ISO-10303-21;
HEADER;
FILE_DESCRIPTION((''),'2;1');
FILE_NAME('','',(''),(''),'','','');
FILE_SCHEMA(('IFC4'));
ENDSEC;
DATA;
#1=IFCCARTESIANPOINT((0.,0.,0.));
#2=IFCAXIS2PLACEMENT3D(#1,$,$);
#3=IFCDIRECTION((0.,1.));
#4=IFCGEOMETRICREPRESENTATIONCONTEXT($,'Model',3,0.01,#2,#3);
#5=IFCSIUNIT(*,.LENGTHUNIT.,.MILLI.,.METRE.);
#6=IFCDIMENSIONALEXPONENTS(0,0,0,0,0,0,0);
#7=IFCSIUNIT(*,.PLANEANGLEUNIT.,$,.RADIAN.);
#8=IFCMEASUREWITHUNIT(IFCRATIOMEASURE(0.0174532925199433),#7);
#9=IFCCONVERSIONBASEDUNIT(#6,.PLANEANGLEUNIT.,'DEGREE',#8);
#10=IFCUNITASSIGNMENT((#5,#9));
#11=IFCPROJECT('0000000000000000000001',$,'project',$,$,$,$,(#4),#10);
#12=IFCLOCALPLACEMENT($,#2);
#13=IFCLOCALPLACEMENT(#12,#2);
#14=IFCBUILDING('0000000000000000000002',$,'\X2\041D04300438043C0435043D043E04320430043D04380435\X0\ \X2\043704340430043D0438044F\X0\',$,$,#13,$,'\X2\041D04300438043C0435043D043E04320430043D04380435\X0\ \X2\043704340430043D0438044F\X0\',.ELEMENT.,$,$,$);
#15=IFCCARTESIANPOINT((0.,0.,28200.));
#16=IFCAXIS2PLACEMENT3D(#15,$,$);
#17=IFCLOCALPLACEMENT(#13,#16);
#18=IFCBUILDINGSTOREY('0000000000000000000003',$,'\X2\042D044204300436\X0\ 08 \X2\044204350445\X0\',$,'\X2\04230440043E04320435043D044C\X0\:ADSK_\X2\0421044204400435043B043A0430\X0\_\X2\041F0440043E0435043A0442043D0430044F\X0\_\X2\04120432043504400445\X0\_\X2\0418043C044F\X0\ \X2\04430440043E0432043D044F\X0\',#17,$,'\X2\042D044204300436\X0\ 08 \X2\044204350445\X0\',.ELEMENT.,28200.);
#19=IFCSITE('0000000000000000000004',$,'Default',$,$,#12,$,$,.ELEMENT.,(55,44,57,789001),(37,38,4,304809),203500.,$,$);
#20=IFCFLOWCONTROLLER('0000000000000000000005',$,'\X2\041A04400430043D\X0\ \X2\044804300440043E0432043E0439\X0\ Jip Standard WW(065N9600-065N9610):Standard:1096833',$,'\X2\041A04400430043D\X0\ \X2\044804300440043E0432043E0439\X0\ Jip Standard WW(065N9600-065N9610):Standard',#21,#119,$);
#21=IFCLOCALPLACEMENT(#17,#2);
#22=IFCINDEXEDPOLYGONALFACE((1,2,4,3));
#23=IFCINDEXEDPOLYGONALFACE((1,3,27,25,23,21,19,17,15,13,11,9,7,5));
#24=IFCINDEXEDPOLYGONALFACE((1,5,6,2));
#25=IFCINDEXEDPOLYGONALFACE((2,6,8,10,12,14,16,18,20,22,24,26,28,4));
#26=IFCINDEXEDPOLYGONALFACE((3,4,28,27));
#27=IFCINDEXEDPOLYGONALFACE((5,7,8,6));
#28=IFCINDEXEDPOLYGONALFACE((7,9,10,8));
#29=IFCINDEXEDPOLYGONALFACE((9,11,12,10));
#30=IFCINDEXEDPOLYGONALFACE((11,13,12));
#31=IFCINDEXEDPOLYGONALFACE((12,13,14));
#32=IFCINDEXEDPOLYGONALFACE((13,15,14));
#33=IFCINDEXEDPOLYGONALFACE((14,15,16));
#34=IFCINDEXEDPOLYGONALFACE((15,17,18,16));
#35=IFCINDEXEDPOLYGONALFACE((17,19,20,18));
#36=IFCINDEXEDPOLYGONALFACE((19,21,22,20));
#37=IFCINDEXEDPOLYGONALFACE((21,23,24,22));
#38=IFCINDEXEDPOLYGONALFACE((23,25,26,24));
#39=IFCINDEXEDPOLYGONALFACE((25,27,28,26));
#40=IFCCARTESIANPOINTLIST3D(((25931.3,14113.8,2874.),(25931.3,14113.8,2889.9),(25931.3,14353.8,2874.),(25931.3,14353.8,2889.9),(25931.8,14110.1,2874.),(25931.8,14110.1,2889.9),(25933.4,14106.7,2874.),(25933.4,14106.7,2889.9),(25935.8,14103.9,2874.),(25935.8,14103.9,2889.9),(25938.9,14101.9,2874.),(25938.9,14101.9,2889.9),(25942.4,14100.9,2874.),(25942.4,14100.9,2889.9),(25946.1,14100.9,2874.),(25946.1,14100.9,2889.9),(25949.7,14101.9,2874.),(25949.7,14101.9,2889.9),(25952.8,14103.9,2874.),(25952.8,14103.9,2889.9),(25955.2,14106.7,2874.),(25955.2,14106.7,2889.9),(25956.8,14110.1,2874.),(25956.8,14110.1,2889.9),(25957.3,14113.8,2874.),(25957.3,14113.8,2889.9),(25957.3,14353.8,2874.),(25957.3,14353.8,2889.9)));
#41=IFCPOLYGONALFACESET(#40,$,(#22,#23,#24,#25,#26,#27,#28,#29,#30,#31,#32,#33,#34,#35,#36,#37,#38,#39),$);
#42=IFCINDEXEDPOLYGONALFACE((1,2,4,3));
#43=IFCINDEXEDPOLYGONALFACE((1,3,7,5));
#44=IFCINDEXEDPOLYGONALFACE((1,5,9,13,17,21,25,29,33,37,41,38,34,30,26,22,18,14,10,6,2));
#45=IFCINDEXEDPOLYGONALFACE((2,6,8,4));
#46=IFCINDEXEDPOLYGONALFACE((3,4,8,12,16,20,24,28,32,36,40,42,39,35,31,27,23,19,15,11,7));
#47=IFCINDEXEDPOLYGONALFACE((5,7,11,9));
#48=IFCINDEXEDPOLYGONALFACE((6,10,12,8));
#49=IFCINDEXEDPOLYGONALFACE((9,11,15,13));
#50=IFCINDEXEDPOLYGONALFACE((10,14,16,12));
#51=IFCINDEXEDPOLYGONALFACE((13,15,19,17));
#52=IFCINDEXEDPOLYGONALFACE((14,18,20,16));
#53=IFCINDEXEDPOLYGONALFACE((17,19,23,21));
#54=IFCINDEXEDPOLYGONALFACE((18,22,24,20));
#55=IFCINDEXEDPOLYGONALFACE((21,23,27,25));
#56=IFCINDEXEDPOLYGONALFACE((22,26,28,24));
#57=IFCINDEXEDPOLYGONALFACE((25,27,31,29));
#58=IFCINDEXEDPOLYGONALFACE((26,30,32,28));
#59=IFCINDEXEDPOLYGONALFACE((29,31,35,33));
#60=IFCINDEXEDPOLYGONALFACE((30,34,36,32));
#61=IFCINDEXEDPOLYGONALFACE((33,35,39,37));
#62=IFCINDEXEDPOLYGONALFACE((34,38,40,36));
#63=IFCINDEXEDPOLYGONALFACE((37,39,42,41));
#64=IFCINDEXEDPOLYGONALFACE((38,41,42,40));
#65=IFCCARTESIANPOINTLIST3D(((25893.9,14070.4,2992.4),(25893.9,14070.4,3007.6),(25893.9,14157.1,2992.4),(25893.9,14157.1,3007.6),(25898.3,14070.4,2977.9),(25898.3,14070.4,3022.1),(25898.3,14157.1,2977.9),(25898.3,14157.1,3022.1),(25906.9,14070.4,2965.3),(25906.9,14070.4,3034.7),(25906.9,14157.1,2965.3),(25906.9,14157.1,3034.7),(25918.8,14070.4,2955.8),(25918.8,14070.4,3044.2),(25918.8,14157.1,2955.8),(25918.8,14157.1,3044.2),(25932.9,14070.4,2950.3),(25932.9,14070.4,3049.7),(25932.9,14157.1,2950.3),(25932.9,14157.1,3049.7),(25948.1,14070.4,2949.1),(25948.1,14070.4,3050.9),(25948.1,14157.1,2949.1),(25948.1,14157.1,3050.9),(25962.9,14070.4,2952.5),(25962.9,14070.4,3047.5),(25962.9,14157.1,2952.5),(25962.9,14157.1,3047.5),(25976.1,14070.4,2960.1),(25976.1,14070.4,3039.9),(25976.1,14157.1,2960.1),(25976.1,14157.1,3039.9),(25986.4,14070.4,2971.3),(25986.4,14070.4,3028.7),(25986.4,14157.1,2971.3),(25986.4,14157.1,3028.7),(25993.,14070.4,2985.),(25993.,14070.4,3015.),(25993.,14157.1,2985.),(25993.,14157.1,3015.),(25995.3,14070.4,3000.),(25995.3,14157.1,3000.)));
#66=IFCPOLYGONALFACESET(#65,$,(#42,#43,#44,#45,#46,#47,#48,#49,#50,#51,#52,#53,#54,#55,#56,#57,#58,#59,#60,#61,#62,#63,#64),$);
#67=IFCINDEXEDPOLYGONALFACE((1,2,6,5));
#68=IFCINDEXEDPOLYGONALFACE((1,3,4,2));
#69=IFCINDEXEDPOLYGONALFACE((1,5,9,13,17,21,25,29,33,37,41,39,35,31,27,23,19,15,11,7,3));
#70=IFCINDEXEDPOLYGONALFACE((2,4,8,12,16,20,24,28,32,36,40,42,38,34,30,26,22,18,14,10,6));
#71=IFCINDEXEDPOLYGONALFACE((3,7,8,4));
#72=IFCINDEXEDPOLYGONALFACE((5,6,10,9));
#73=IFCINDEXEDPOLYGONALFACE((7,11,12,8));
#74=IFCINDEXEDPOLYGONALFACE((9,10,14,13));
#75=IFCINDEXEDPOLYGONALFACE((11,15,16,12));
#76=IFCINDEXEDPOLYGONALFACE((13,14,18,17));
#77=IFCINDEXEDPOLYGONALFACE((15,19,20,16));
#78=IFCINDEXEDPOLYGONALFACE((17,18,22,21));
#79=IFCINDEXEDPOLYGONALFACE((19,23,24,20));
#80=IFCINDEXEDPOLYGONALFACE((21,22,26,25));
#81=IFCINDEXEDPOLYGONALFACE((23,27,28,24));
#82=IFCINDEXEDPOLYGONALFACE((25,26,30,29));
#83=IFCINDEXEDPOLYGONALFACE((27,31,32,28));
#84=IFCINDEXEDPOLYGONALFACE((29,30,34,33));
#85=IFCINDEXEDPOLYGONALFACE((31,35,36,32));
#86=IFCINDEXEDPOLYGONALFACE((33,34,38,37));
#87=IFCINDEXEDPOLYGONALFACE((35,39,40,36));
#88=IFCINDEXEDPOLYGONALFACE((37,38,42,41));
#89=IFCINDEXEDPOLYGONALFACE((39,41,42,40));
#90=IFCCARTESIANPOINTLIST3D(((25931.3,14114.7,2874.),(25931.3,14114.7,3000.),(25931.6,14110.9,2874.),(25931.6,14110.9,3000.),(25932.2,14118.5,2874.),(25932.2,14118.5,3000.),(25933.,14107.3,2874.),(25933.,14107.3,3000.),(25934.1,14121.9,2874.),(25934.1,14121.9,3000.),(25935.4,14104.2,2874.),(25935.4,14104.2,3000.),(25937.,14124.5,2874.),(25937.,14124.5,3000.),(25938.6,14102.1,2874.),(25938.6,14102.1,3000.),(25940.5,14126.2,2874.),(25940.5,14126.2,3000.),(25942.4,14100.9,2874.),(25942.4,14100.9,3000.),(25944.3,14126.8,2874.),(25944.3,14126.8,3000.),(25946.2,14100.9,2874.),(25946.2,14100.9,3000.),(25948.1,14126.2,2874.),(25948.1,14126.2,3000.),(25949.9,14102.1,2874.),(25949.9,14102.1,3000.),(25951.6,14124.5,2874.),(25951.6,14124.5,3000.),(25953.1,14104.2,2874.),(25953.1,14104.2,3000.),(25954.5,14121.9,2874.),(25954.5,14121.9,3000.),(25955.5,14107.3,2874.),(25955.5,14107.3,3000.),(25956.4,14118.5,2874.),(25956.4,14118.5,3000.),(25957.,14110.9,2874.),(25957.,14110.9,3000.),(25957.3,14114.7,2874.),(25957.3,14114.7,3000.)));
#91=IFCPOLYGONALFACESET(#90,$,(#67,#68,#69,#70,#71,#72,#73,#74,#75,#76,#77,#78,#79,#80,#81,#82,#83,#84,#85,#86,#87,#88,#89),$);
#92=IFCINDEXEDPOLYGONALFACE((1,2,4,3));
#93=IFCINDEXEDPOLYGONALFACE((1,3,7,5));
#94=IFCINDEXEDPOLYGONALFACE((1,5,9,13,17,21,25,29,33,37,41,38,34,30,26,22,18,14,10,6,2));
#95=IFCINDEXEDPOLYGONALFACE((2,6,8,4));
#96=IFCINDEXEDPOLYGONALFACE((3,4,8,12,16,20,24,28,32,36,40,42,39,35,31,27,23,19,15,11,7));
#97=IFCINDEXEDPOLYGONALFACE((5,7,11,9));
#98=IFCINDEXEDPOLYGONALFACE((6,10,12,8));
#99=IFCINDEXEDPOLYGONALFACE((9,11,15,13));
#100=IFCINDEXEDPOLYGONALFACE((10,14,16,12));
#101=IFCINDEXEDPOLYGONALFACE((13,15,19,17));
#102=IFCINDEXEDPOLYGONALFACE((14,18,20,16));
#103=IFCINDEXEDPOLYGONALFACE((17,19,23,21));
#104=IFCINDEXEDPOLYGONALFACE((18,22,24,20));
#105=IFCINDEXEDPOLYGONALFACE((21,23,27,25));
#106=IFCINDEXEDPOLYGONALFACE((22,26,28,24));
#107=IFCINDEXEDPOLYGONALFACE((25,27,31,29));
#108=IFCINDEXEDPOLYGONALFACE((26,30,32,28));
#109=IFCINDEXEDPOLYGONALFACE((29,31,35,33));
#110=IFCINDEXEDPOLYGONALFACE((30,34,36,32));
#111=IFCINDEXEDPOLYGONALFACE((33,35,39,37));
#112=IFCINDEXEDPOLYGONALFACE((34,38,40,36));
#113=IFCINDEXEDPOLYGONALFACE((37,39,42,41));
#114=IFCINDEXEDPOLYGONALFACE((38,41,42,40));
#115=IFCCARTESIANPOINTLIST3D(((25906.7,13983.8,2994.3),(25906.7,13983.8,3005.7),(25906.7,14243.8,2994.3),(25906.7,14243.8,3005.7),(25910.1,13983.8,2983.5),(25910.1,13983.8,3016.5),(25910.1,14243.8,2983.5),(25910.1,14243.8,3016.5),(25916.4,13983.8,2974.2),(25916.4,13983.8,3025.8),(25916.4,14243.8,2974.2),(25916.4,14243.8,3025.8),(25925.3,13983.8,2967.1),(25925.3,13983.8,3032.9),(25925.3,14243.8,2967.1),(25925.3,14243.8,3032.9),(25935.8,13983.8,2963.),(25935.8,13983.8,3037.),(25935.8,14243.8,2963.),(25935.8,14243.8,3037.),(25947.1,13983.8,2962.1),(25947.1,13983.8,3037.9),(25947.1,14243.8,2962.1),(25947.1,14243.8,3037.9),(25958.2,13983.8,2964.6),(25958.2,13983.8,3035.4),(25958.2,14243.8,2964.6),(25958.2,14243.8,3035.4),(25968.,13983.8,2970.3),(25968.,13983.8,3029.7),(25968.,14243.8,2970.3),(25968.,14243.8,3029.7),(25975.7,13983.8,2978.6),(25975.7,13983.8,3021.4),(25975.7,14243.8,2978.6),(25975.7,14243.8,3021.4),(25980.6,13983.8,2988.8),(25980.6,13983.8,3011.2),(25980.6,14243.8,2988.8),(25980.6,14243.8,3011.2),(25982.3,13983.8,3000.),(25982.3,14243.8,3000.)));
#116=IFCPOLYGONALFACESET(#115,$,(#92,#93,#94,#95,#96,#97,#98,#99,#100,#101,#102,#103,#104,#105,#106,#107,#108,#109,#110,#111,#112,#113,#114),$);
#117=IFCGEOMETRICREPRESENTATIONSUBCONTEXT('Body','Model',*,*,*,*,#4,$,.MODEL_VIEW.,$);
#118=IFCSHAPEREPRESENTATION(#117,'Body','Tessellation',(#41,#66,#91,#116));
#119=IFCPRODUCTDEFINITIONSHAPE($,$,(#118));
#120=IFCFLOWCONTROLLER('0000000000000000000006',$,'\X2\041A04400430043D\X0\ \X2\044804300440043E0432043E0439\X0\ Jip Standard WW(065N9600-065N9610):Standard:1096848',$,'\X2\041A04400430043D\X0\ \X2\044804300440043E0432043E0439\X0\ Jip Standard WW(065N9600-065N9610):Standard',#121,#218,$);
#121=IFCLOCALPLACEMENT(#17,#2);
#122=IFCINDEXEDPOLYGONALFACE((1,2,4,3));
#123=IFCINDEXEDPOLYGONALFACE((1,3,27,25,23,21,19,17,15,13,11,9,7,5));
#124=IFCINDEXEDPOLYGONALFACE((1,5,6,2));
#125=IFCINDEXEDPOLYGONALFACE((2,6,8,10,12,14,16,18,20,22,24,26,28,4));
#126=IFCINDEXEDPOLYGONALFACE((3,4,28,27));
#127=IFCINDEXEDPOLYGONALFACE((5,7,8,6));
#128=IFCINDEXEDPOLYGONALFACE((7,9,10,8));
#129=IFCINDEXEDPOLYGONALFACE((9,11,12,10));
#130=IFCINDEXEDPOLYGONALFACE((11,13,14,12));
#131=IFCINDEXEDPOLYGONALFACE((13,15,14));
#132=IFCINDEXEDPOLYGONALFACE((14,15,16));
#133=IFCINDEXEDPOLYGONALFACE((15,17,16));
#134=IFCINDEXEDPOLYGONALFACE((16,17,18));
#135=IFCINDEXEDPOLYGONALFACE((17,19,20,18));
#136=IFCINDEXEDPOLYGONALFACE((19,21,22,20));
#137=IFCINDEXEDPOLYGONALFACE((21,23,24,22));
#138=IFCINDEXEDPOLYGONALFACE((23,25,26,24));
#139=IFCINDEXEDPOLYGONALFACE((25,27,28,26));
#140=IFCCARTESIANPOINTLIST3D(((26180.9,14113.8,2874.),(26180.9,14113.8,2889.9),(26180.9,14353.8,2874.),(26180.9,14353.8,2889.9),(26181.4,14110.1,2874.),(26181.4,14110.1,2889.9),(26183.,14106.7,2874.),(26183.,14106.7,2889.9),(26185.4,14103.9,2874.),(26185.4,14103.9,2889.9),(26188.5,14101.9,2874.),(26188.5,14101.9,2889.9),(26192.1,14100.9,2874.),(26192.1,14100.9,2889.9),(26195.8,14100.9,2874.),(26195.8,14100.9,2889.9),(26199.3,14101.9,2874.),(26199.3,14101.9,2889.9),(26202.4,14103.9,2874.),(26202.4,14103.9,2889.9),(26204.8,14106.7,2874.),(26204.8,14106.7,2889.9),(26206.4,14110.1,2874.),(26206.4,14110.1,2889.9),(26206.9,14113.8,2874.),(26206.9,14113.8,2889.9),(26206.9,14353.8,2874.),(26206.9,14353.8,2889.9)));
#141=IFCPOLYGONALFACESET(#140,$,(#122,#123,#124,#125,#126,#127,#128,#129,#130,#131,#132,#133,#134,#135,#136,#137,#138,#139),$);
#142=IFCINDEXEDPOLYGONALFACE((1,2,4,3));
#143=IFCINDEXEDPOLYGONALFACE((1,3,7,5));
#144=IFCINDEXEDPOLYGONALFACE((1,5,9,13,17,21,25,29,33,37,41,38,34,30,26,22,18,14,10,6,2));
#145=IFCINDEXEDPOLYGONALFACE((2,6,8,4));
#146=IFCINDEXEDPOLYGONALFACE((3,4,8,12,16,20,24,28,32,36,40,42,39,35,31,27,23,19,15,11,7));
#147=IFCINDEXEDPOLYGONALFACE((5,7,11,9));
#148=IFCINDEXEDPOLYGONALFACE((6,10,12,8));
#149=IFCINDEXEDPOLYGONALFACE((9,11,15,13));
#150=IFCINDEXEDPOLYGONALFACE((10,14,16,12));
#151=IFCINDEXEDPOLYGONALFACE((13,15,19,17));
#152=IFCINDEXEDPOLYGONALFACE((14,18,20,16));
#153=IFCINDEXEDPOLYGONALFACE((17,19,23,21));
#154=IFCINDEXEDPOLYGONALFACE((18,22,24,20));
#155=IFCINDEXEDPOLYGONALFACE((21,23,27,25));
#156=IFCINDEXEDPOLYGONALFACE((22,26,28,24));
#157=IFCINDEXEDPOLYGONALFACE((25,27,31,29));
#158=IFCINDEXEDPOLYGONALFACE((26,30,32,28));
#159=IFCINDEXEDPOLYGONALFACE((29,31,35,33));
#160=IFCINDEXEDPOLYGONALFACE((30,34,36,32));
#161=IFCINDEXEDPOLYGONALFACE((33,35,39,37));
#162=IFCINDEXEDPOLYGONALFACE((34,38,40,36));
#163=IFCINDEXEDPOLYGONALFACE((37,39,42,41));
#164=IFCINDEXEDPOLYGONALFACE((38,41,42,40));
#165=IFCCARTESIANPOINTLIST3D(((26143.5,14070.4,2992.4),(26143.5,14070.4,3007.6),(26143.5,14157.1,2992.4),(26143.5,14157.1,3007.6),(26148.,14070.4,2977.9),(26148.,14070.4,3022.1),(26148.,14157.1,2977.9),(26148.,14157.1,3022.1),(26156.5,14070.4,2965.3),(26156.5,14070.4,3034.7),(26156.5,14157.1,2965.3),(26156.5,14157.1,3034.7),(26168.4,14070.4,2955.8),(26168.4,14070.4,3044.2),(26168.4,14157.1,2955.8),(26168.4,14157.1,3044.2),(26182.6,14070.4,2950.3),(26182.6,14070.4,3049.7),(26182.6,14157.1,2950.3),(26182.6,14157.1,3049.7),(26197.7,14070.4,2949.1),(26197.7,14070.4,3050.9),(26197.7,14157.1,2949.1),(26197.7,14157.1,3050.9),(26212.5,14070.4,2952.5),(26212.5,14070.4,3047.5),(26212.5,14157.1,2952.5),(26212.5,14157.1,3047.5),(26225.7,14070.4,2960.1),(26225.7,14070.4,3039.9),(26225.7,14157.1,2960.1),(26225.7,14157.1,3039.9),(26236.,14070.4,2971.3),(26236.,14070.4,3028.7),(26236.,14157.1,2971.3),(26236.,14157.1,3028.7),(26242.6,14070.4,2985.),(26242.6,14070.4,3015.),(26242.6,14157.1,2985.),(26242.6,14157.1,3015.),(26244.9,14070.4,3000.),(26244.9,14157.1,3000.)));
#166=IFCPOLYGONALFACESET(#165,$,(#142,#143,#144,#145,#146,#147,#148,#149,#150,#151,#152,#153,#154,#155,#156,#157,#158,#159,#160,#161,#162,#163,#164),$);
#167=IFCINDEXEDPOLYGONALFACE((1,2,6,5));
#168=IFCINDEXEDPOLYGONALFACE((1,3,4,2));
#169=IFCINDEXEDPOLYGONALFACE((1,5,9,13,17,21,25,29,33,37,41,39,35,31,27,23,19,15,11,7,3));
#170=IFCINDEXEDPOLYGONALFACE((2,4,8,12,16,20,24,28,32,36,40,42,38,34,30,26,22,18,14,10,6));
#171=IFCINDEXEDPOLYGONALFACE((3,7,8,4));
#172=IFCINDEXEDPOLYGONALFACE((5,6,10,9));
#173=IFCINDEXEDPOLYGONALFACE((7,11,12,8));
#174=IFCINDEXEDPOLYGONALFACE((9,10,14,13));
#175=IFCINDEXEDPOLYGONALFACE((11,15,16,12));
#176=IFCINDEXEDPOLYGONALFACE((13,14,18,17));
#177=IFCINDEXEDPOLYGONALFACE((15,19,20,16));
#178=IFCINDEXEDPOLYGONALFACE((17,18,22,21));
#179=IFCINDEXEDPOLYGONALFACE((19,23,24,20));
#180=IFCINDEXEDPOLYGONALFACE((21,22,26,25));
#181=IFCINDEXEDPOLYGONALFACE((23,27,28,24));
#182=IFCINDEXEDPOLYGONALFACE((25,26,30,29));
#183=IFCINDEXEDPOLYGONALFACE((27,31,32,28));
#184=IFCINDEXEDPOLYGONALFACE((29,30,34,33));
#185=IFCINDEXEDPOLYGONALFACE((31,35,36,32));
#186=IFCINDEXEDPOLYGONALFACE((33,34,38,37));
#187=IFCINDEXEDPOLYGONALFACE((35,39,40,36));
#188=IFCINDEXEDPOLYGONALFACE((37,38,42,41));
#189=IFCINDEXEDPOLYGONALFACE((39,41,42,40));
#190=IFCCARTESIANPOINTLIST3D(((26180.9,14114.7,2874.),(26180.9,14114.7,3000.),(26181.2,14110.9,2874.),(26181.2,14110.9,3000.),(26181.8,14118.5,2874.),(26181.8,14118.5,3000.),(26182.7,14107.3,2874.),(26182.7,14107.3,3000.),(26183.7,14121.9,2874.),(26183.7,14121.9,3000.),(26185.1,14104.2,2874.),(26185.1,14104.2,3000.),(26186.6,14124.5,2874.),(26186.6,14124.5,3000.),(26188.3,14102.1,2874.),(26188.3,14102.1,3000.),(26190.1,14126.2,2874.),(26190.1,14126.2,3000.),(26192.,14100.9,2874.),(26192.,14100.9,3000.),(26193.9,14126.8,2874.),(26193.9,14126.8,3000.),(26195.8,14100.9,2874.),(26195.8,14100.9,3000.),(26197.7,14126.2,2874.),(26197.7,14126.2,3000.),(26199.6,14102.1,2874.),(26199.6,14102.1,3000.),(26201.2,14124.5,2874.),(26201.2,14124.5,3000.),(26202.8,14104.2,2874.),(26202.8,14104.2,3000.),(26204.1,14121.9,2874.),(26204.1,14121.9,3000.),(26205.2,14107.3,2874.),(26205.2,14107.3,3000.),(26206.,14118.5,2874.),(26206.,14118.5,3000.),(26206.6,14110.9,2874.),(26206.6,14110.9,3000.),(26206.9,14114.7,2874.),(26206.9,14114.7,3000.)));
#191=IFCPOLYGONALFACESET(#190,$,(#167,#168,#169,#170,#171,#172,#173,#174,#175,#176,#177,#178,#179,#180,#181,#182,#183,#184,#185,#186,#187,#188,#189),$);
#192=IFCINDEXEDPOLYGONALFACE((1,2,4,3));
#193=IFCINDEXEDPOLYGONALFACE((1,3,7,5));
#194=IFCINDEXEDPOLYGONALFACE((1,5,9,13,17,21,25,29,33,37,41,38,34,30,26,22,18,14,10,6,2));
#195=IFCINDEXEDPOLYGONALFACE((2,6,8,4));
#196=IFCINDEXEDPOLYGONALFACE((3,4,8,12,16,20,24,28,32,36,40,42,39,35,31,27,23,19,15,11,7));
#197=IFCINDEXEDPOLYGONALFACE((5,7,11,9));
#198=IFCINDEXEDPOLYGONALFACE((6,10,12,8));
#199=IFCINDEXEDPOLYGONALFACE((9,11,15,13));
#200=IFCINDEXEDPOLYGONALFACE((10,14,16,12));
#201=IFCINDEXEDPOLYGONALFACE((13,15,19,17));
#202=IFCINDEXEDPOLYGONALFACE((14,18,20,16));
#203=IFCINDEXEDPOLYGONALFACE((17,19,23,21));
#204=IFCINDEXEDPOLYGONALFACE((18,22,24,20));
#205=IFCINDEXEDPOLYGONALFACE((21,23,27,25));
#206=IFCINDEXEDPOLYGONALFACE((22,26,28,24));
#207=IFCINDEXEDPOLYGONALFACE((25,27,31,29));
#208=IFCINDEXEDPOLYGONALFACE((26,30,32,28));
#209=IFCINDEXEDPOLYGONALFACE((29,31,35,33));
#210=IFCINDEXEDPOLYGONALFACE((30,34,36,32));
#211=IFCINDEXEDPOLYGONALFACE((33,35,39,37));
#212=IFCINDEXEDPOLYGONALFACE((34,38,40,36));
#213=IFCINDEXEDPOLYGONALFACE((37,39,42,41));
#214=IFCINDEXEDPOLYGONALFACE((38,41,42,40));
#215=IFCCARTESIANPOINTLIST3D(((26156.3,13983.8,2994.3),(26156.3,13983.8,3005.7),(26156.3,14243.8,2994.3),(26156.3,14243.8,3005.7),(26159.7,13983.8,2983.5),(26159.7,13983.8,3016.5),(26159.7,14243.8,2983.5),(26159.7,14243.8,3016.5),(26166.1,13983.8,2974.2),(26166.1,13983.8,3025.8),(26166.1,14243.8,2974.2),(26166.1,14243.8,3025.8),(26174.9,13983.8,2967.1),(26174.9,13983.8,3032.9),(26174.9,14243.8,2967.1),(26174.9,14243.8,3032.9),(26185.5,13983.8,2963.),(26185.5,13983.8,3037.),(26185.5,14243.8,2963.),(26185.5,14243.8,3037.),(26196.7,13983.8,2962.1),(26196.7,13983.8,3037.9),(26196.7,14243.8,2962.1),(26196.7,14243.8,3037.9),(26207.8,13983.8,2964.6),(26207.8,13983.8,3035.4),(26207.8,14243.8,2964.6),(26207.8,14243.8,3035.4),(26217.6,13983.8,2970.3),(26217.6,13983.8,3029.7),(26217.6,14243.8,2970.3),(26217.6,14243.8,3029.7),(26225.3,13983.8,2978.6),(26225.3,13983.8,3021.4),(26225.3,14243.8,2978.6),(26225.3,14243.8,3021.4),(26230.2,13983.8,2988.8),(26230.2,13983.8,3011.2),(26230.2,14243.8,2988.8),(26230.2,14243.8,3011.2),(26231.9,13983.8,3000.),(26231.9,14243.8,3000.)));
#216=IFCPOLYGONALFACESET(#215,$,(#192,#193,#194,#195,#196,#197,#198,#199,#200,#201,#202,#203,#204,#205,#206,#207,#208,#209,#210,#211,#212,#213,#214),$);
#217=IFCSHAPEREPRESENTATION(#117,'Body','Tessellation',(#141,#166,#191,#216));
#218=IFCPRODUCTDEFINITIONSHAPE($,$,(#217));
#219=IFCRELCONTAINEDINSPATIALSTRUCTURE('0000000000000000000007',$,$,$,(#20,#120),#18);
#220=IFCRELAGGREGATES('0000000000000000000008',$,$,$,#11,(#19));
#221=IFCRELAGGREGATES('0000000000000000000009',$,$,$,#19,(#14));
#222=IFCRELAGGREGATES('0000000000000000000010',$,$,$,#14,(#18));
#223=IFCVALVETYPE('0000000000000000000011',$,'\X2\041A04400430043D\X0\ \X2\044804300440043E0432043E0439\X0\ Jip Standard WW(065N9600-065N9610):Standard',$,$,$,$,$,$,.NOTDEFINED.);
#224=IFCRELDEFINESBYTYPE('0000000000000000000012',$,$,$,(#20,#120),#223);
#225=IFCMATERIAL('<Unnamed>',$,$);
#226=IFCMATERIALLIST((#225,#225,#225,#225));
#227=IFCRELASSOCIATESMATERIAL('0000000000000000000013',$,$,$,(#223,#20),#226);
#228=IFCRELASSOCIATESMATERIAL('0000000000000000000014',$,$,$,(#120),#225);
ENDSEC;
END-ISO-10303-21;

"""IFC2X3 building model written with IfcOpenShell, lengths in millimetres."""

from ifc_helpers import new_model, entity, si_unit, converted_unit, direction, frame, frame_2d, origin, origin_2d_with_axis, place, context, subcontext, project, spatial, polyline, circle_curve, parameter, trimmed, segment, composite_curve, circle, outline, extrude, source, transform, mapped, material, material_list, type_object, type_shapes, element, save


model = new_model("IFC2X3")

# Units and contexts
model_context = context("Model", 3, precision=0.01, world=origin(), true_north=direction((0.0, 1.0)))
body_context = subcontext(model_context, "Body", "Model", "MODEL_VIEW")
ifc_project = project(units=[si_unit("LENGTHUNIT", "METRE", prefix="MILLI"), converted_unit("PLANEANGLEUNIT", "DEGREE", entity("IfcRatioMeasure", 0.0174532925199433), si_unit("PLANEANGLEUNIT", "RADIAN"), dimensions=[0, 0, 0, 0, 0, 0, 0])], contexts=[model_context])

# Site, building, storey
site_placement = place(None, origin())
site = spatial("IfcSite", under=ifc_project, at=site_placement, Name="Default", CompositionType="ELEMENT", RefLatitude=(55, 44, 57, 789001), RefLongitude=(37, 38, 4, 304809), RefElevation=203500.0)
building_placement = place(site_placement, origin())
building = spatial("IfcBuilding", under=site, at=building_placement, Name="Наименование здания", LongName="Наименование здания", CompositionType="ELEMENT")
storey_placement = place(building_placement, frame((0.0, 0.0, 28200.0)))
storey = spatial("IfcBuildingStorey", under=building, at=storey_placement, Name="Этаж 08 тех", ObjectType="Уровень:ADSK_Стрелка_Проектная_Вверх_Имя уровня", LongName="Этаж 08 тех", CompositionType="ELEMENT", Elevation=28200.0)

# Shared definitions
ifc_material = material(Name="<Unnamed>")

# Flow controllers
ifc_material_list_1 = material_list([ifc_material, ifc_material, ifc_material, ifc_material])
valve_type_1 = type_object("IfcValveType", Name="Кран шаровой Jip Standard WW(065N9600-065N9610):Standard", PredefinedType="NOTDEFINED", material=ifc_material_list_1)
shared_shape_1 = source(origin(), body_context, "Body", "SweptSolid", [
    extrude(outline(composite_curve([segment(polyline([(-120.0, -13.0), (120.0, -13.0)]), True, "CONTINUOUS"), segment(polyline([(120.0, -13.0), (120.0, 13.0)]), True, "CONTINUOUS"), segment(polyline([(120.0, 13.0), (-120.0, 13.0)]), True, "CONTINUOUS"), segment(trimmed(circle_curve(frame_2d((-120.0, 0.0), x_axis=(1.0, 0.0)), 13.0), [parameter(90.0)], [parameter(270.0)], True, "PARAMETER"), True, "CONTINUOUS")], self_intersect=False)), frame((120.0, 0.0, 110.1)), (0.0, 0.0, 1.0), 15.9),
    extrude(circle(Radius=51.0, at=origin_2d_with_axis()), frame((-43.3, 0.0, 0.0), z_axis=(1.0, 0.0, 0.0), x_axis=(0.0, 1.0, 0.0)), (0.0, 0.0, 1.0), 86.7),
    extrude(circle(Radius=13.0, at=origin_2d_with_axis()), origin(), (0.0, 0.0, 1.0), 126.0),
    extrude(circle(Radius=38.0, at=origin_2d_with_axis()), frame((-130.0, 0.0, 0.0), z_axis=(1.0, 0.0, 0.0), x_axis=(0.0, 1.0, 0.0)), (0.0, 0.0, 1.0), 260.0),
])
type_shapes(valve_type_1, [shared_shape_1])
flow_controller_1_placement = place(storey_placement, frame((25944.3, 14113.8, 3000.0), z_axis=(0.0, 0.0, -1.0), x_axis=(0.0, 1.0, 0.0)))
element("IfcFlowController", 1, at=flow_controller_1_placement, inside=storey, type_object=valve_type_1, material=ifc_material_list_1, Name="Кран шаровой Jip Standard WW(065N9600-065N9610):Standard:1096833", ObjectType="Кран шаровой Jip Standard WW(065N9600-065N9610):Standard", context=body_context, shape_type="MappedRepresentation", body=[
    mapped(shared_shape_1, transform((0.0, 0.0, 0.0), scale=1.0)),
])
flow_controller_2_placement = place(storey_placement, frame((26193.9, 14113.8, 3000.0), z_axis=(0.0, 0.0, -1.0), x_axis=(0.0, 1.0, 0.0)))
element("IfcFlowController", 2, at=flow_controller_2_placement, inside=storey, type_object=valve_type_1, material=ifc_material, Name="Кран шаровой Jip Standard WW(065N9600-065N9610):Standard:1096848", ObjectType="Кран шаровой Jip Standard WW(065N9600-065N9610):Standard", context=body_context, shape_type="MappedRepresentation", body=[
    mapped(shared_shape_1, transform((0.0, 0.0, 0.0), scale=1.0)),
])

save(model, "model.ifc")
